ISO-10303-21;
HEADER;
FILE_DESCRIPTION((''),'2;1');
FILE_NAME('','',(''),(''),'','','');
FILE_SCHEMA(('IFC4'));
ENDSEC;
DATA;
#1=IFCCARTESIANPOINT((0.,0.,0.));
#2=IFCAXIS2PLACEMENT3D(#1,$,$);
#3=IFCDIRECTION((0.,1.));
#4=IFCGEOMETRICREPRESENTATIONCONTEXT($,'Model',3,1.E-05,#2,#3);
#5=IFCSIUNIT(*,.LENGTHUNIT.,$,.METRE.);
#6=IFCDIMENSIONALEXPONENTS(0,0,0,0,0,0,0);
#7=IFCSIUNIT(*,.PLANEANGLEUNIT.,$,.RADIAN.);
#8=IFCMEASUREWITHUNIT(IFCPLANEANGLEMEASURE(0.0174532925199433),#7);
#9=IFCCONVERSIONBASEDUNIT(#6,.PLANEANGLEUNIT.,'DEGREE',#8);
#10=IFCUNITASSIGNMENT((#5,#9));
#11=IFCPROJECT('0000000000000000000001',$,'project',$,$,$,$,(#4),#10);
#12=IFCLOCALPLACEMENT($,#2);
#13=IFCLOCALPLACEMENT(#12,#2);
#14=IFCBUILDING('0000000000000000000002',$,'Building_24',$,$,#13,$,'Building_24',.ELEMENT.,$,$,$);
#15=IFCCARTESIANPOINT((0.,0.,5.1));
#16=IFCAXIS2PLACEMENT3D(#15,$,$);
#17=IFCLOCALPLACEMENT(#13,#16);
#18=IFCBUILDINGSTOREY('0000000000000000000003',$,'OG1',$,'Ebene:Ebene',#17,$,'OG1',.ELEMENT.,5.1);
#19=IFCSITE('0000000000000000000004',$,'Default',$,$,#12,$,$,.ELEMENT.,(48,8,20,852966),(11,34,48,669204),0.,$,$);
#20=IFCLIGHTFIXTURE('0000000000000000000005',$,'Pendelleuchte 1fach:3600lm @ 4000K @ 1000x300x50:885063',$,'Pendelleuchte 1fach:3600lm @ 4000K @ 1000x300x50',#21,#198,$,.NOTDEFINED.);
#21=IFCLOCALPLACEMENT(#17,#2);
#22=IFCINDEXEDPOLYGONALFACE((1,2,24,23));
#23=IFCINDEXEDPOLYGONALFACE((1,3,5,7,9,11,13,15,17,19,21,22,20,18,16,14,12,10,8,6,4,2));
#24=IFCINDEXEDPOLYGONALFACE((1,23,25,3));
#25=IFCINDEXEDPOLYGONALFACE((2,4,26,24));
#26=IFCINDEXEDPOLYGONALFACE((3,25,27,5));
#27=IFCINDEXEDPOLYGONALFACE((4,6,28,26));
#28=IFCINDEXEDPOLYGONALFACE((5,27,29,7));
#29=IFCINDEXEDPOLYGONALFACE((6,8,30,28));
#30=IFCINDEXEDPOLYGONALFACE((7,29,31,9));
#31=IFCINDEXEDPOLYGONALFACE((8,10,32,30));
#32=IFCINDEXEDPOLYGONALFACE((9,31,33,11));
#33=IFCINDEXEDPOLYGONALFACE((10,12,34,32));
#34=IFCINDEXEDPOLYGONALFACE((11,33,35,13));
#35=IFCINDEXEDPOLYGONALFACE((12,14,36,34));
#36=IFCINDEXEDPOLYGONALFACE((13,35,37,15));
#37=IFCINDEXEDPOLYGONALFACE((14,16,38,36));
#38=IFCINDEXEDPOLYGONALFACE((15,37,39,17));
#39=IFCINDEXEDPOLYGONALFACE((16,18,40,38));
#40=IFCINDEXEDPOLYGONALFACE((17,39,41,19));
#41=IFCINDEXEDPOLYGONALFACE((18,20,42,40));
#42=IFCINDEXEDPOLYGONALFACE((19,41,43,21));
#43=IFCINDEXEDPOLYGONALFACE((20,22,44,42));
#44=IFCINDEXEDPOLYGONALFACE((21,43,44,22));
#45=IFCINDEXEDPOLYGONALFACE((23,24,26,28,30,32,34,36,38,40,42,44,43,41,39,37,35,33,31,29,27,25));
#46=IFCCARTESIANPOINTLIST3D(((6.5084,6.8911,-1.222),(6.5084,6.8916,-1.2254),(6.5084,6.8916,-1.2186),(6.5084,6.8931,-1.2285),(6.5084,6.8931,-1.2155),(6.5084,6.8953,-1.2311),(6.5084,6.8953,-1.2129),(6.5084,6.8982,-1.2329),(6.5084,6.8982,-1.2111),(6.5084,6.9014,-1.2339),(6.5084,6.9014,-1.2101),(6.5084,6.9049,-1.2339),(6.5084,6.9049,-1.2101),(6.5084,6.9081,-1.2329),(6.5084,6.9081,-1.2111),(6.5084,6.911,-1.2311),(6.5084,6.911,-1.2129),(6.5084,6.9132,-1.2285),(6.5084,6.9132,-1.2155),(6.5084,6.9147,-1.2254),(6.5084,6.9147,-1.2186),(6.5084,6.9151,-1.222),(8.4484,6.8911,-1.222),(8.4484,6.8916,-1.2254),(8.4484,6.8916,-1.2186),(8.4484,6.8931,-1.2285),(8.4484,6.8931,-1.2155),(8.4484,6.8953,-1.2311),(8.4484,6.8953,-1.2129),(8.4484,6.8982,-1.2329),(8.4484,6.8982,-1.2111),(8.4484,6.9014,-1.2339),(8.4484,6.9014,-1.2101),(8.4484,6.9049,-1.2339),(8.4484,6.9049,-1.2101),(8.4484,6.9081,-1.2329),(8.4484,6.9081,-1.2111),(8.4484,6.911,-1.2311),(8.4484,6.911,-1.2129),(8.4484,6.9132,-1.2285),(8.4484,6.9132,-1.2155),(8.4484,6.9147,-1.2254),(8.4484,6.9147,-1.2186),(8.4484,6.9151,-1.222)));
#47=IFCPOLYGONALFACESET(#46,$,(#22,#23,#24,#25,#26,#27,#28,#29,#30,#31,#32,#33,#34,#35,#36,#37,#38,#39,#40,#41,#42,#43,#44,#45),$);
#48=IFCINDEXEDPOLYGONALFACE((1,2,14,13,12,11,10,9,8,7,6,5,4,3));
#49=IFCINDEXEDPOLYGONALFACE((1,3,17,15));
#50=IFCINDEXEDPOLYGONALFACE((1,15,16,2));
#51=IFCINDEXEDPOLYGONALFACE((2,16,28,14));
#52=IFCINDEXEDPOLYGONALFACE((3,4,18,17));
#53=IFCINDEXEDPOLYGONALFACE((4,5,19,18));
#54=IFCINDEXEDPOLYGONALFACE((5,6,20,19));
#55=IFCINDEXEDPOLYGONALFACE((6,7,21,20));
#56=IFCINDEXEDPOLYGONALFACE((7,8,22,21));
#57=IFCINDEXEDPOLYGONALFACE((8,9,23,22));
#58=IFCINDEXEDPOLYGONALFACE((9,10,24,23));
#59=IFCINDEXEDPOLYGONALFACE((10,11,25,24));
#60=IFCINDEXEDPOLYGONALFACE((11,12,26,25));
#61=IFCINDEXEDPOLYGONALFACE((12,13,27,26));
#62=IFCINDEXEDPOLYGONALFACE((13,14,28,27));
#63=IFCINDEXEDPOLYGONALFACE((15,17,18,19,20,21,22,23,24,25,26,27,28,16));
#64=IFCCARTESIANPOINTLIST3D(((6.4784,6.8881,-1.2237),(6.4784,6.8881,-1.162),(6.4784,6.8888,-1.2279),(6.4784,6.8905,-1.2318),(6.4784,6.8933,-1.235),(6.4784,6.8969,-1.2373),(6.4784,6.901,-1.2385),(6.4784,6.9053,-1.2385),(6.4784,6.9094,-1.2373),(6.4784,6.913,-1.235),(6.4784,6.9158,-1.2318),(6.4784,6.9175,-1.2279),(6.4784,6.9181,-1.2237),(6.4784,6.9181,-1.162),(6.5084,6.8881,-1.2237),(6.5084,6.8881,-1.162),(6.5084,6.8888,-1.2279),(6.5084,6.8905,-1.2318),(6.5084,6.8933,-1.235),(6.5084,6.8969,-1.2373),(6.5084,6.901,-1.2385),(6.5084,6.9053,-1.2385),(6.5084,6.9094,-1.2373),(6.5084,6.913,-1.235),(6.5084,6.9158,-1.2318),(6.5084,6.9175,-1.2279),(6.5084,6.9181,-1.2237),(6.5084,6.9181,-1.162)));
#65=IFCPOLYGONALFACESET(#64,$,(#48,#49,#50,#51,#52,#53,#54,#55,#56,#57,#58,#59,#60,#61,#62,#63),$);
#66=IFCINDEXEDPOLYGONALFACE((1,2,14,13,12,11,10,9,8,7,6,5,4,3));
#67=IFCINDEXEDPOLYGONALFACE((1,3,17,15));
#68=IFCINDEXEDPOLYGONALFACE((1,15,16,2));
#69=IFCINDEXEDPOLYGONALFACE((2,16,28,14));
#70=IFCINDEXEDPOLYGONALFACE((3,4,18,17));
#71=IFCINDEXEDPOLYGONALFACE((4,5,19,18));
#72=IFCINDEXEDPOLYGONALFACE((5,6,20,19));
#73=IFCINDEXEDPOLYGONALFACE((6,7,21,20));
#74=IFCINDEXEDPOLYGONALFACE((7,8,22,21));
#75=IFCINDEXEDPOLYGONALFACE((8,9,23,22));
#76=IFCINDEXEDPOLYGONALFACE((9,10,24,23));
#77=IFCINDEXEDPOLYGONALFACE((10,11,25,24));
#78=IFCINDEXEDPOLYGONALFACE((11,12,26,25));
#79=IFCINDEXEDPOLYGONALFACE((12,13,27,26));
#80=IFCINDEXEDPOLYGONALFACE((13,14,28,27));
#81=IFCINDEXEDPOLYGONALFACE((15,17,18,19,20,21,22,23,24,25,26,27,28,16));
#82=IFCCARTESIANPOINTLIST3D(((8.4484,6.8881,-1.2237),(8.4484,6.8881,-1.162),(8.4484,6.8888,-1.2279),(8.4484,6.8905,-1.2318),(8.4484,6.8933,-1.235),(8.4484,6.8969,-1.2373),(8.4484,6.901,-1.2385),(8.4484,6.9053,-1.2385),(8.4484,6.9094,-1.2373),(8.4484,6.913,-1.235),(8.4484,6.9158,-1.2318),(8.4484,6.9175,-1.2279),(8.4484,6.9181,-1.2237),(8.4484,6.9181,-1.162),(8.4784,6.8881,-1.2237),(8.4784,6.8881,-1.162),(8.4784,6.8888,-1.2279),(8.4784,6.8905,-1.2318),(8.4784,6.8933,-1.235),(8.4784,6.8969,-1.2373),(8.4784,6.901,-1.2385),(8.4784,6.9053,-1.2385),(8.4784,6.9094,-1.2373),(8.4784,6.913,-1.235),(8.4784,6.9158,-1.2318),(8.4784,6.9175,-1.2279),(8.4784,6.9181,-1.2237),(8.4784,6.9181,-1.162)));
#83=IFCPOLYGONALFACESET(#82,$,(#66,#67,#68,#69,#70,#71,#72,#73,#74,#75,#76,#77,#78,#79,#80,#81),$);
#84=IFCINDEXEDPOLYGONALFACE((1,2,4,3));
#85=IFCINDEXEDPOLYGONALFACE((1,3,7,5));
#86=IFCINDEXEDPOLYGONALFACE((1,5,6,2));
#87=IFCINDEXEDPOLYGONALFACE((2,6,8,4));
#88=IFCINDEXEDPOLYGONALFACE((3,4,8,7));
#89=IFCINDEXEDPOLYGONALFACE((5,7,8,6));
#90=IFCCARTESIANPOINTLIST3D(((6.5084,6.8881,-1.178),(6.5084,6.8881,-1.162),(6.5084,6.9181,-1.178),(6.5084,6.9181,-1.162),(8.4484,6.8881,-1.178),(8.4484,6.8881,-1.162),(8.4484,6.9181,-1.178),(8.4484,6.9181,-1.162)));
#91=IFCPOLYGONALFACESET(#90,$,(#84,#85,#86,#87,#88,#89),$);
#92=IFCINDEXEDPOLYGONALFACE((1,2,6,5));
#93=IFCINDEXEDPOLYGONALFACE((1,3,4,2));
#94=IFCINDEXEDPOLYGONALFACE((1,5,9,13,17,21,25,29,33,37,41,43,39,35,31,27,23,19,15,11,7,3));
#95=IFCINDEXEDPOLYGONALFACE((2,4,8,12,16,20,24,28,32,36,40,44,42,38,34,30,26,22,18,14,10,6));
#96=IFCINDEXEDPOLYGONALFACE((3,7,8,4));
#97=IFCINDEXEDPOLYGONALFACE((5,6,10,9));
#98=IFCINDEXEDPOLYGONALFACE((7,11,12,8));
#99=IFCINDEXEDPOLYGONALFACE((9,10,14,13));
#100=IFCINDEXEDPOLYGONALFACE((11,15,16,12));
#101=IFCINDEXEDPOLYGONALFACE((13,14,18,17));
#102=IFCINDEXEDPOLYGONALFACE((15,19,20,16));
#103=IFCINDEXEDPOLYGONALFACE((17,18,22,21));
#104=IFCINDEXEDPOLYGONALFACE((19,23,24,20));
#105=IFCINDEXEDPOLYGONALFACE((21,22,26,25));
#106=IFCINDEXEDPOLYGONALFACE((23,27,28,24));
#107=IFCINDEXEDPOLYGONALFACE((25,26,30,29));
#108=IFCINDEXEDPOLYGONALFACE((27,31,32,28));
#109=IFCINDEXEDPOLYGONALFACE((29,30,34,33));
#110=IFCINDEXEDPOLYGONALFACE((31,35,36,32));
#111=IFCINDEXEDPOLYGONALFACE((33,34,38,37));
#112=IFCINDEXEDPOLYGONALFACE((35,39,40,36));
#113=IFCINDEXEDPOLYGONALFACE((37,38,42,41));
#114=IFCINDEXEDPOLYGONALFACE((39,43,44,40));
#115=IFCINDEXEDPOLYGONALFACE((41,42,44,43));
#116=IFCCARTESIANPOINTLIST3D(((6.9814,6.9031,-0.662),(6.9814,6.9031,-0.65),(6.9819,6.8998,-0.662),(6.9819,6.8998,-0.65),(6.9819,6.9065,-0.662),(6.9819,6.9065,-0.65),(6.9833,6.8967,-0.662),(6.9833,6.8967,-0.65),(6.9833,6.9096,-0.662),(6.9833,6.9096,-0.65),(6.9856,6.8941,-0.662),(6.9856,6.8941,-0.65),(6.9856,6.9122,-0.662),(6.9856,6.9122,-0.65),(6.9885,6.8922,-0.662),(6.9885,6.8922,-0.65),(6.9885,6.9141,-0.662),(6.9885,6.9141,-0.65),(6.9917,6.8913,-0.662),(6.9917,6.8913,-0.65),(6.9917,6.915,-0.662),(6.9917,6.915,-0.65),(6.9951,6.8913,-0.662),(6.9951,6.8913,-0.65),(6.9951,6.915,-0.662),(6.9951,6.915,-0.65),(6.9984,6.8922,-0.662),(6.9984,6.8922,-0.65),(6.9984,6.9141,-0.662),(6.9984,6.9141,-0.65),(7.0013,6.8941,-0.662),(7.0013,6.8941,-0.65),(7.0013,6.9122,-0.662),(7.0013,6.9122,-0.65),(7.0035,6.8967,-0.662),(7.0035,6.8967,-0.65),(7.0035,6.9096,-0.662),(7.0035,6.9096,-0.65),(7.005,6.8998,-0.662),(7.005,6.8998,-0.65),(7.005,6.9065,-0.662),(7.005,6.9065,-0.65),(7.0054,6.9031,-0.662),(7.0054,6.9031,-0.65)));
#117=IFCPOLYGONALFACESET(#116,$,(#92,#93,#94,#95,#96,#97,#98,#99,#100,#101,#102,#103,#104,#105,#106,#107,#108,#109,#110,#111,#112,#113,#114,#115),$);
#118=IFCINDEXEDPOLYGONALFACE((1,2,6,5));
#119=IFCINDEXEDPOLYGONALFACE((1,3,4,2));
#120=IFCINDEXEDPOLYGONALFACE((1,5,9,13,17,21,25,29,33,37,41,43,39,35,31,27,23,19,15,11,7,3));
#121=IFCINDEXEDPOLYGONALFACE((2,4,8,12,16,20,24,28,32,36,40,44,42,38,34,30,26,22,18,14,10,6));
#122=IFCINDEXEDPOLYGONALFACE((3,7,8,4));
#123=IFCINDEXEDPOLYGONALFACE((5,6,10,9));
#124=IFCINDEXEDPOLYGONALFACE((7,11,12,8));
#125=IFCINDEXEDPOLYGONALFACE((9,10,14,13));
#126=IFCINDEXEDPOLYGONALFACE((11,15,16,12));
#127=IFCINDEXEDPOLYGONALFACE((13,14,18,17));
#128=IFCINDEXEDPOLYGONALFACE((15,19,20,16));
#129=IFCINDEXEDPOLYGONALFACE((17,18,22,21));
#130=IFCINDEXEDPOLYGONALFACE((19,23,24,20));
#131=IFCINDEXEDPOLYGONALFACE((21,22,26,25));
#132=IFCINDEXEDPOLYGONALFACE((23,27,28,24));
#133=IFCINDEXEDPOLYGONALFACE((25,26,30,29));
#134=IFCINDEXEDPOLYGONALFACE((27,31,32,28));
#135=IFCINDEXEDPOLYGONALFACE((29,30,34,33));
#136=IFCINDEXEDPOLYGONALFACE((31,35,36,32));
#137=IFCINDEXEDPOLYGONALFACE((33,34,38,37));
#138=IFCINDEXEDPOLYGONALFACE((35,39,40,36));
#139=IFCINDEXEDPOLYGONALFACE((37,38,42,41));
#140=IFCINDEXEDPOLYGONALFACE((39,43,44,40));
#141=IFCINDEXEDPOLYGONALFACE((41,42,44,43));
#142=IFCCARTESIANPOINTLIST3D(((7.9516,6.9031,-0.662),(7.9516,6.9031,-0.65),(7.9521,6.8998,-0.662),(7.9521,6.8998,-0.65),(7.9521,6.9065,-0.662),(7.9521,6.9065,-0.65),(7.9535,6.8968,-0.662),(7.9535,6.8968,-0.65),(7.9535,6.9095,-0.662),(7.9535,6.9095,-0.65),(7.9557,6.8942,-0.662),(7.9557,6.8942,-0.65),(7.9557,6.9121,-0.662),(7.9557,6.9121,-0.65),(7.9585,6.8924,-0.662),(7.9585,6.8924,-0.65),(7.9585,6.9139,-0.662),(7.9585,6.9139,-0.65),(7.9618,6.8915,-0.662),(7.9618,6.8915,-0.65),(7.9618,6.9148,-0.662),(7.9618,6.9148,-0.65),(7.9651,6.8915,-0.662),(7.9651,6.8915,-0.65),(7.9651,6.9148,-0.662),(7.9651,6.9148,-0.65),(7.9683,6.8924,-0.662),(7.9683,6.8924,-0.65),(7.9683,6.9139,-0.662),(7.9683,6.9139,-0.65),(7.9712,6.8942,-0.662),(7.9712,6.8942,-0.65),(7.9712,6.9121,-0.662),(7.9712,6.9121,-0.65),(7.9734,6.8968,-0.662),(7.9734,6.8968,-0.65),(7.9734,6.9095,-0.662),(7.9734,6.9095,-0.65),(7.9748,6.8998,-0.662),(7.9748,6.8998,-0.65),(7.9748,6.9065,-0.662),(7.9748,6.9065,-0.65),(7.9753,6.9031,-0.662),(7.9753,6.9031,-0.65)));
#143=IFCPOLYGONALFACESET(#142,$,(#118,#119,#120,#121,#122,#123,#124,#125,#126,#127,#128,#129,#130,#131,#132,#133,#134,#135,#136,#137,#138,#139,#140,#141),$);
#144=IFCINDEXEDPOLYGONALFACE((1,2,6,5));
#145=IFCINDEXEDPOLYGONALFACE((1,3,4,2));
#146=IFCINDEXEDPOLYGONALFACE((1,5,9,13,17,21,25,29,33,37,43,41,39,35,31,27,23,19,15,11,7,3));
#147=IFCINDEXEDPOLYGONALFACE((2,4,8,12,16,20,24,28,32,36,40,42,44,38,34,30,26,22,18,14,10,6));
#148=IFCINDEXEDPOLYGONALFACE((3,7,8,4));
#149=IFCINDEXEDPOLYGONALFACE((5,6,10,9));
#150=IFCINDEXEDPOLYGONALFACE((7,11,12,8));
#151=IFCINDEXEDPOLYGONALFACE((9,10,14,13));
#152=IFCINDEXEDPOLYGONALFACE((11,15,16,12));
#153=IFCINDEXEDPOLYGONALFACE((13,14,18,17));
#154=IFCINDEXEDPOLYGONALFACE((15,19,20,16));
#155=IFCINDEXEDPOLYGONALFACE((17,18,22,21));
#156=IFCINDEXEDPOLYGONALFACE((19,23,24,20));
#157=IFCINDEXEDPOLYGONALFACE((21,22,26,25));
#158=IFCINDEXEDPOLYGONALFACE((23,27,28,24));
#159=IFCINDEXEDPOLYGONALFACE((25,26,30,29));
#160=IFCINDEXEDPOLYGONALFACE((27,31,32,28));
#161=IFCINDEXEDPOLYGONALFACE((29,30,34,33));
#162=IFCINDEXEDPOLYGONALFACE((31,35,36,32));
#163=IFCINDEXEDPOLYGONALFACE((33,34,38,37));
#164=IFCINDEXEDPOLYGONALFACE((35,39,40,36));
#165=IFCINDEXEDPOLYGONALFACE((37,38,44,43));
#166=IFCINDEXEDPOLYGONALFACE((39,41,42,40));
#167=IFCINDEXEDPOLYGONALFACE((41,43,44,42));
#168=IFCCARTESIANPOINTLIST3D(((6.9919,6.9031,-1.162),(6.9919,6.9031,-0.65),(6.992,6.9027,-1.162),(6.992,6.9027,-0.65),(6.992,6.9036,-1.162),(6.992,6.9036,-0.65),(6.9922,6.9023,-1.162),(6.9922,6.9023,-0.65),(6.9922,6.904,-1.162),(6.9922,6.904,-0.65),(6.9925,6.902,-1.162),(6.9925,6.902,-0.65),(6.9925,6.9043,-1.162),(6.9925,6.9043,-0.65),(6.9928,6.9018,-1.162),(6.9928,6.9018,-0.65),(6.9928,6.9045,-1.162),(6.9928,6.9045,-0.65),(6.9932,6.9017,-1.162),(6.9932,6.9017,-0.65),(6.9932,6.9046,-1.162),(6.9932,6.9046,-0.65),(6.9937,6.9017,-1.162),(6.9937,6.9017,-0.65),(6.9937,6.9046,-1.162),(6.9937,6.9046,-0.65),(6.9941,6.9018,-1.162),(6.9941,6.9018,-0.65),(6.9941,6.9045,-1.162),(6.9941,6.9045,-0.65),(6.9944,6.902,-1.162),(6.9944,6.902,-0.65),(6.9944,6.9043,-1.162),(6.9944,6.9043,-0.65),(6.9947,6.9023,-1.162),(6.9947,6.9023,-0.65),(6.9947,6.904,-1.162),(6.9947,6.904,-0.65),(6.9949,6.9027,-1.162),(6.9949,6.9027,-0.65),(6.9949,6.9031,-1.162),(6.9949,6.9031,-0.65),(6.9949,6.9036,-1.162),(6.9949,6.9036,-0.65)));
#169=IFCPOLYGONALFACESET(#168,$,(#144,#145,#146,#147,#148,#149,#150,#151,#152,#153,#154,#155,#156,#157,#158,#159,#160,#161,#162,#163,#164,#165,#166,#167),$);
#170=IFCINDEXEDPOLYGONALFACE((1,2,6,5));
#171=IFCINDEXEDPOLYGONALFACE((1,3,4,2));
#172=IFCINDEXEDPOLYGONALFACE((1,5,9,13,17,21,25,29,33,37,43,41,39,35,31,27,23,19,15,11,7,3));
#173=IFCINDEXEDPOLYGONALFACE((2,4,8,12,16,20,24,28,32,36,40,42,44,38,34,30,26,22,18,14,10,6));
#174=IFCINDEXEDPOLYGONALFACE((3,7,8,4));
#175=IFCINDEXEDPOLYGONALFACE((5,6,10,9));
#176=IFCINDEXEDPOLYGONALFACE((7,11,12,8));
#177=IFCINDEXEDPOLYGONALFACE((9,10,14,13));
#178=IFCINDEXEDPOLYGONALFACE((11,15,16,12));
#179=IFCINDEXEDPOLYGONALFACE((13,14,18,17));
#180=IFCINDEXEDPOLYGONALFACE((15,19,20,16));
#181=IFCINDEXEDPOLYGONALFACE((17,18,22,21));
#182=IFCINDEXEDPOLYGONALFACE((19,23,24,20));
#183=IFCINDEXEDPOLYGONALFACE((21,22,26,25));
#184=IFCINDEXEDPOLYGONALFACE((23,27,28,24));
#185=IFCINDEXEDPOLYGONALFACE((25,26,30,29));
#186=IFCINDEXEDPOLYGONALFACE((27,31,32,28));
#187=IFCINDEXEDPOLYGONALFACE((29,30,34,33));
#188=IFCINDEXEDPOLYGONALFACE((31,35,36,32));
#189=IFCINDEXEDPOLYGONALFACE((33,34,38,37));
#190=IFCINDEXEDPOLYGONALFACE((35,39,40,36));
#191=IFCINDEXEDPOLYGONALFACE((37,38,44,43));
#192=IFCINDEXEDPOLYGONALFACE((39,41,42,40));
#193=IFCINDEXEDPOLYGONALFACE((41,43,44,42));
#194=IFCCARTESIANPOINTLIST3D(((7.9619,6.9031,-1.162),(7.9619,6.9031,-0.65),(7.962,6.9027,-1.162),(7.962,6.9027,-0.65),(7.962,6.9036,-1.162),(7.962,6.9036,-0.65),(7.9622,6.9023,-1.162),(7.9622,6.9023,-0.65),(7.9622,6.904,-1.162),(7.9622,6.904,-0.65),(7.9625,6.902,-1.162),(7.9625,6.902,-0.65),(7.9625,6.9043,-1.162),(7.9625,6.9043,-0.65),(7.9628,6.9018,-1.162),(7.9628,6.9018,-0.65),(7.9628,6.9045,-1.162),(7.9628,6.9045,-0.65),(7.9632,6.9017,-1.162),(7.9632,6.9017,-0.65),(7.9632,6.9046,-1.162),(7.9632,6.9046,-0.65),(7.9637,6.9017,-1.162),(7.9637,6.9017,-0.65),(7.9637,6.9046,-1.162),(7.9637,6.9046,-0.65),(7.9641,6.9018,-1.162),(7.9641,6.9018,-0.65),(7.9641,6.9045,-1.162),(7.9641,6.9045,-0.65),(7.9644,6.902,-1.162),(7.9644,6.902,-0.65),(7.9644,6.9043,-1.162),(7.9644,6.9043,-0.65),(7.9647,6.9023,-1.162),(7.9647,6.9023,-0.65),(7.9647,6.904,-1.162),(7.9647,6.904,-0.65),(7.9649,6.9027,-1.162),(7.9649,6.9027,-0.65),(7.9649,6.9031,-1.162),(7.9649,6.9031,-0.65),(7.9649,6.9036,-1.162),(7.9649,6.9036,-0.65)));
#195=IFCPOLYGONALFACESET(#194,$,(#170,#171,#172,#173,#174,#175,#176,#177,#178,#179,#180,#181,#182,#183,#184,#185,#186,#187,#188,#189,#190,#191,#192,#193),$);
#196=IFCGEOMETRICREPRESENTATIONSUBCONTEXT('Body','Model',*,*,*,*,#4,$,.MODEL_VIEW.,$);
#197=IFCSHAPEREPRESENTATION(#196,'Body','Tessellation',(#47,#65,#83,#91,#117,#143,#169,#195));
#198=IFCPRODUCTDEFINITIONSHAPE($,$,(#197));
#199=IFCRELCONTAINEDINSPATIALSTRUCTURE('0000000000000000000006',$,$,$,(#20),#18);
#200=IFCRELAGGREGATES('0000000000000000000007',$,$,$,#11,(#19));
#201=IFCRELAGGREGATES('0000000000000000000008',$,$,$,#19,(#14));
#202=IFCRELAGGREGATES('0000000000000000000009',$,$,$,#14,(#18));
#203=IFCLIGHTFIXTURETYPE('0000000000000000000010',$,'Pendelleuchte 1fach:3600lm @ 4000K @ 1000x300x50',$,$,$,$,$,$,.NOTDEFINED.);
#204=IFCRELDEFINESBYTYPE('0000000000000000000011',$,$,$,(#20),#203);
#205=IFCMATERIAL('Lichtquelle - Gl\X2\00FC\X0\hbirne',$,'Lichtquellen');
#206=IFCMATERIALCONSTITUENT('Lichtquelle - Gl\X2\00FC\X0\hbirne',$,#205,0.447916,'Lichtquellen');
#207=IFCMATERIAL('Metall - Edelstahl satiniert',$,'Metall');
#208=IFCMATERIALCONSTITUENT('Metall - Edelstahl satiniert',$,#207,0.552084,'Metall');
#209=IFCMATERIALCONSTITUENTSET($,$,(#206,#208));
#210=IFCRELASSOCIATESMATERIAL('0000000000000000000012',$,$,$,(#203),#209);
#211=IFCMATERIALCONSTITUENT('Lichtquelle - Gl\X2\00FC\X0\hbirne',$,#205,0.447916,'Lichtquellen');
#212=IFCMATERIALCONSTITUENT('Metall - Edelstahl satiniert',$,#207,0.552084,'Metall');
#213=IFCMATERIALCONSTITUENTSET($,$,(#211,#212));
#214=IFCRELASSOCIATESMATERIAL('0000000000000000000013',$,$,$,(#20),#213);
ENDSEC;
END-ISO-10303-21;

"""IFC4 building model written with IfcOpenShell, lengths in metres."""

from ifc_helpers import new_model, entity, si_unit, converted_unit, direction, frame, origin, place, context, subcontext, project, spatial, line, arc, indexed_curve, outline, extrude, source, transform, mapped, material, constituent, constituent_set, type_object, type_shapes, element, save


model = new_model("IFC4")

# Units and contexts
model_context = context("Model", 3, precision=1e-05, world=origin(), true_north=direction((0.0, 1.0)))
body_context = subcontext(model_context, "Body", "Model", "MODEL_VIEW")
ifc_project = project(units=[si_unit("LENGTHUNIT", "METRE"), converted_unit("PLANEANGLEUNIT", "DEGREE", entity("IfcPlaneAngleMeasure", 0.0174532925199433), si_unit("PLANEANGLEUNIT", "RADIAN"), dimensions=[0, 0, 0, 0, 0, 0, 0])], contexts=[model_context])

# Site, building, storey
site_placement = place(None, origin())
site = spatial("IfcSite", under=ifc_project, at=site_placement, Name="Default", CompositionType="ELEMENT", RefLatitude=(48, 8, 20, 852966), RefLongitude=(11, 34, 48, 669204), RefElevation=0.0)
building_placement = place(site_placement, origin())
building = spatial("IfcBuilding", under=site, at=building_placement, Name="Building_24", LongName="Building_24", CompositionType="ELEMENT")
storey_placement = place(building_placement, frame((0.0, 0.0, 5.1)))
storey = spatial("IfcBuildingStorey", under=building, at=storey_placement, Name="OG1", ObjectType="Ebene:Ebene", LongName="OG1", CompositionType="ELEMENT", Elevation=5.1)

# Light fixture
ifc_material_1 = material(Name="Lichtquelle - Glühbirne", Category="Lichtquellen")
ifc_material_2 = material(Name="Metall - Edelstahl satiniert", Category="Metall")
ifc_constituent_1 = constituent(ifc_material_1, Name="Lichtquelle - Glühbirne", Category="Lichtquellen", fraction=0.447916)
ifc_constituent_2 = constituent(ifc_material_2, Name="Metall - Edelstahl satiniert", Category="Metall", fraction=0.552084)
ifc_constituent_set_1 = constituent_set(constituents=[ifc_constituent_1, ifc_constituent_2])
light_fixture_type = type_object("IfcLightFixtureType", Name="Pendelleuchte 1fach:3600lm @ 4000K @ 1000x300x50", PredefinedType="NOTDEFINED", material=ifc_constituent_set_1)
shared_shape_1 = source(origin(), body_context, "Body", "SweptSolid", [
    extrude(outline(indexed_curve([(-0.012, 0.0), (0.0, -0.012), (0.012, 0.0), (0.0, 0.012)], segments=[arc(1, 2, 3), arc(3, 4, 1)], self_intersect=False)), frame((-0.97, 0.0, -0.572), z_axis=(1.0, 0.0, 0.0), x_axis=(0.0, -1.0, 0.0)), (0.0, 0.0, 1.0), 1.94),
    extrude(outline(indexed_curve([(0.015, 0.0308), (0.0, 0.0458), (-0.015, 0.0308), (-0.015, -0.0308), (0.015, -0.0308)], segments=[arc(1, 2, 3), line(3, 4, 5, 1)], self_intersect=False)), frame((0.97, 0.0, -0.5428), z_axis=(1.0, 0.0, 0.0), x_axis=(0.0, -1.0, 0.0)), (0.0, 0.0, 1.0), 0.03),
    extrude(outline(indexed_curve([(0.015, 0.0308), (0.0, 0.0458), (-0.015, 0.0308), (-0.015, -0.0308), (0.015, -0.0308)], segments=[arc(1, 2, 3), line(3, 4, 5, 1)], self_intersect=False)), frame((-1.0, 0.0, -0.5428), z_axis=(1.0, 0.0, 0.0), x_axis=(0.0, -1.0, 0.0)), (0.0, 0.0, 1.0), 0.03),
    extrude(outline(indexed_curve([(-0.015, -0.97), (0.015, -0.97), (0.015, 0.97), (-0.015, 0.97), (-0.015, -0.97)], self_intersect=False)), frame((0.0, 0.0, -0.528), z_axis=(0.0, 0.0, 1.0), x_axis=(0.0, 1.0, 0.0)), (0.0, 0.0, 1.0), 0.016),
    extrude(outline(indexed_curve([(-0.012, 0.0), (0.0, -0.012), (0.012, 0.0), (0.0, 0.012)], segments=[arc(1, 2, 3), arc(3, 4, 1)], self_intersect=False)), frame((0.485, 0.0, -0.012)), (0.0, 0.0, 1.0), 0.012),
    extrude(outline(indexed_curve([(-0.0118, 0.0), (0.0, -0.0118), (0.0118, 0.0), (0.0, 0.0118)], segments=[arc(1, 2, 3), arc(3, 4, 1)], self_intersect=False)), frame((-0.485, 0.0, -0.012)), (0.0, 0.0, 1.0), 0.012),
    extrude(outline(indexed_curve([(-0.0015, 0.0), (0.0, -0.0015), (0.0015, 0.0), (0.0, 0.0015)], segments=[arc(1, 2, 3), arc(3, 4, 1)], self_intersect=False)), frame((0.485, 0.0, -0.512)), (0.0, 0.0, 1.0), 0.512),
    extrude(outline(indexed_curve([(-0.0015, 0.0), (0.0, -0.0015), (0.0015, 0.0), (0.0, 0.0015)], segments=[arc(1, 2, 3), arc(3, 4, 1)], self_intersect=False)), frame((-0.485, 0.0, -0.512)), (0.0, 0.0, 1.0), 0.512),
])
type_shapes(light_fixture_type, [shared_shape_1])
ifc_constituent_3 = constituent(ifc_material_1, Name="Lichtquelle - Glühbirne", Category="Lichtquellen", fraction=0.447916)
ifc_constituent_4 = constituent(ifc_material_2, Name="Metall - Edelstahl satiniert", Category="Metall", fraction=0.552084)
ifc_constituent_set_2 = constituent_set(constituents=[ifc_constituent_3, ifc_constituent_4])
light_fixture_1_placement = place(storey_placement, frame((7.4784, 6.9031, -0.65), z_axis=(0.0, 0.0, 1.0), x_axis=(-1.0, 0.0, 0.0)))
element("IfcLightFixture", 1, at=light_fixture_1_placement, inside=storey, type_object=light_fixture_type, material=ifc_constituent_set_2, Name="Pendelleuchte 1fach:3600lm @ 4000K @ 1000x300x50:885063", ObjectType="Pendelleuchte 1fach:3600lm @ 4000K @ 1000x300x50", PredefinedType="NOTDEFINED", context=body_context, shape_type="MappedRepresentation", body=[
    mapped(shared_shape_1, transform((0.0, 0.0, 0.0), scale=1.0)),
])

save(model, "model.ifc")
